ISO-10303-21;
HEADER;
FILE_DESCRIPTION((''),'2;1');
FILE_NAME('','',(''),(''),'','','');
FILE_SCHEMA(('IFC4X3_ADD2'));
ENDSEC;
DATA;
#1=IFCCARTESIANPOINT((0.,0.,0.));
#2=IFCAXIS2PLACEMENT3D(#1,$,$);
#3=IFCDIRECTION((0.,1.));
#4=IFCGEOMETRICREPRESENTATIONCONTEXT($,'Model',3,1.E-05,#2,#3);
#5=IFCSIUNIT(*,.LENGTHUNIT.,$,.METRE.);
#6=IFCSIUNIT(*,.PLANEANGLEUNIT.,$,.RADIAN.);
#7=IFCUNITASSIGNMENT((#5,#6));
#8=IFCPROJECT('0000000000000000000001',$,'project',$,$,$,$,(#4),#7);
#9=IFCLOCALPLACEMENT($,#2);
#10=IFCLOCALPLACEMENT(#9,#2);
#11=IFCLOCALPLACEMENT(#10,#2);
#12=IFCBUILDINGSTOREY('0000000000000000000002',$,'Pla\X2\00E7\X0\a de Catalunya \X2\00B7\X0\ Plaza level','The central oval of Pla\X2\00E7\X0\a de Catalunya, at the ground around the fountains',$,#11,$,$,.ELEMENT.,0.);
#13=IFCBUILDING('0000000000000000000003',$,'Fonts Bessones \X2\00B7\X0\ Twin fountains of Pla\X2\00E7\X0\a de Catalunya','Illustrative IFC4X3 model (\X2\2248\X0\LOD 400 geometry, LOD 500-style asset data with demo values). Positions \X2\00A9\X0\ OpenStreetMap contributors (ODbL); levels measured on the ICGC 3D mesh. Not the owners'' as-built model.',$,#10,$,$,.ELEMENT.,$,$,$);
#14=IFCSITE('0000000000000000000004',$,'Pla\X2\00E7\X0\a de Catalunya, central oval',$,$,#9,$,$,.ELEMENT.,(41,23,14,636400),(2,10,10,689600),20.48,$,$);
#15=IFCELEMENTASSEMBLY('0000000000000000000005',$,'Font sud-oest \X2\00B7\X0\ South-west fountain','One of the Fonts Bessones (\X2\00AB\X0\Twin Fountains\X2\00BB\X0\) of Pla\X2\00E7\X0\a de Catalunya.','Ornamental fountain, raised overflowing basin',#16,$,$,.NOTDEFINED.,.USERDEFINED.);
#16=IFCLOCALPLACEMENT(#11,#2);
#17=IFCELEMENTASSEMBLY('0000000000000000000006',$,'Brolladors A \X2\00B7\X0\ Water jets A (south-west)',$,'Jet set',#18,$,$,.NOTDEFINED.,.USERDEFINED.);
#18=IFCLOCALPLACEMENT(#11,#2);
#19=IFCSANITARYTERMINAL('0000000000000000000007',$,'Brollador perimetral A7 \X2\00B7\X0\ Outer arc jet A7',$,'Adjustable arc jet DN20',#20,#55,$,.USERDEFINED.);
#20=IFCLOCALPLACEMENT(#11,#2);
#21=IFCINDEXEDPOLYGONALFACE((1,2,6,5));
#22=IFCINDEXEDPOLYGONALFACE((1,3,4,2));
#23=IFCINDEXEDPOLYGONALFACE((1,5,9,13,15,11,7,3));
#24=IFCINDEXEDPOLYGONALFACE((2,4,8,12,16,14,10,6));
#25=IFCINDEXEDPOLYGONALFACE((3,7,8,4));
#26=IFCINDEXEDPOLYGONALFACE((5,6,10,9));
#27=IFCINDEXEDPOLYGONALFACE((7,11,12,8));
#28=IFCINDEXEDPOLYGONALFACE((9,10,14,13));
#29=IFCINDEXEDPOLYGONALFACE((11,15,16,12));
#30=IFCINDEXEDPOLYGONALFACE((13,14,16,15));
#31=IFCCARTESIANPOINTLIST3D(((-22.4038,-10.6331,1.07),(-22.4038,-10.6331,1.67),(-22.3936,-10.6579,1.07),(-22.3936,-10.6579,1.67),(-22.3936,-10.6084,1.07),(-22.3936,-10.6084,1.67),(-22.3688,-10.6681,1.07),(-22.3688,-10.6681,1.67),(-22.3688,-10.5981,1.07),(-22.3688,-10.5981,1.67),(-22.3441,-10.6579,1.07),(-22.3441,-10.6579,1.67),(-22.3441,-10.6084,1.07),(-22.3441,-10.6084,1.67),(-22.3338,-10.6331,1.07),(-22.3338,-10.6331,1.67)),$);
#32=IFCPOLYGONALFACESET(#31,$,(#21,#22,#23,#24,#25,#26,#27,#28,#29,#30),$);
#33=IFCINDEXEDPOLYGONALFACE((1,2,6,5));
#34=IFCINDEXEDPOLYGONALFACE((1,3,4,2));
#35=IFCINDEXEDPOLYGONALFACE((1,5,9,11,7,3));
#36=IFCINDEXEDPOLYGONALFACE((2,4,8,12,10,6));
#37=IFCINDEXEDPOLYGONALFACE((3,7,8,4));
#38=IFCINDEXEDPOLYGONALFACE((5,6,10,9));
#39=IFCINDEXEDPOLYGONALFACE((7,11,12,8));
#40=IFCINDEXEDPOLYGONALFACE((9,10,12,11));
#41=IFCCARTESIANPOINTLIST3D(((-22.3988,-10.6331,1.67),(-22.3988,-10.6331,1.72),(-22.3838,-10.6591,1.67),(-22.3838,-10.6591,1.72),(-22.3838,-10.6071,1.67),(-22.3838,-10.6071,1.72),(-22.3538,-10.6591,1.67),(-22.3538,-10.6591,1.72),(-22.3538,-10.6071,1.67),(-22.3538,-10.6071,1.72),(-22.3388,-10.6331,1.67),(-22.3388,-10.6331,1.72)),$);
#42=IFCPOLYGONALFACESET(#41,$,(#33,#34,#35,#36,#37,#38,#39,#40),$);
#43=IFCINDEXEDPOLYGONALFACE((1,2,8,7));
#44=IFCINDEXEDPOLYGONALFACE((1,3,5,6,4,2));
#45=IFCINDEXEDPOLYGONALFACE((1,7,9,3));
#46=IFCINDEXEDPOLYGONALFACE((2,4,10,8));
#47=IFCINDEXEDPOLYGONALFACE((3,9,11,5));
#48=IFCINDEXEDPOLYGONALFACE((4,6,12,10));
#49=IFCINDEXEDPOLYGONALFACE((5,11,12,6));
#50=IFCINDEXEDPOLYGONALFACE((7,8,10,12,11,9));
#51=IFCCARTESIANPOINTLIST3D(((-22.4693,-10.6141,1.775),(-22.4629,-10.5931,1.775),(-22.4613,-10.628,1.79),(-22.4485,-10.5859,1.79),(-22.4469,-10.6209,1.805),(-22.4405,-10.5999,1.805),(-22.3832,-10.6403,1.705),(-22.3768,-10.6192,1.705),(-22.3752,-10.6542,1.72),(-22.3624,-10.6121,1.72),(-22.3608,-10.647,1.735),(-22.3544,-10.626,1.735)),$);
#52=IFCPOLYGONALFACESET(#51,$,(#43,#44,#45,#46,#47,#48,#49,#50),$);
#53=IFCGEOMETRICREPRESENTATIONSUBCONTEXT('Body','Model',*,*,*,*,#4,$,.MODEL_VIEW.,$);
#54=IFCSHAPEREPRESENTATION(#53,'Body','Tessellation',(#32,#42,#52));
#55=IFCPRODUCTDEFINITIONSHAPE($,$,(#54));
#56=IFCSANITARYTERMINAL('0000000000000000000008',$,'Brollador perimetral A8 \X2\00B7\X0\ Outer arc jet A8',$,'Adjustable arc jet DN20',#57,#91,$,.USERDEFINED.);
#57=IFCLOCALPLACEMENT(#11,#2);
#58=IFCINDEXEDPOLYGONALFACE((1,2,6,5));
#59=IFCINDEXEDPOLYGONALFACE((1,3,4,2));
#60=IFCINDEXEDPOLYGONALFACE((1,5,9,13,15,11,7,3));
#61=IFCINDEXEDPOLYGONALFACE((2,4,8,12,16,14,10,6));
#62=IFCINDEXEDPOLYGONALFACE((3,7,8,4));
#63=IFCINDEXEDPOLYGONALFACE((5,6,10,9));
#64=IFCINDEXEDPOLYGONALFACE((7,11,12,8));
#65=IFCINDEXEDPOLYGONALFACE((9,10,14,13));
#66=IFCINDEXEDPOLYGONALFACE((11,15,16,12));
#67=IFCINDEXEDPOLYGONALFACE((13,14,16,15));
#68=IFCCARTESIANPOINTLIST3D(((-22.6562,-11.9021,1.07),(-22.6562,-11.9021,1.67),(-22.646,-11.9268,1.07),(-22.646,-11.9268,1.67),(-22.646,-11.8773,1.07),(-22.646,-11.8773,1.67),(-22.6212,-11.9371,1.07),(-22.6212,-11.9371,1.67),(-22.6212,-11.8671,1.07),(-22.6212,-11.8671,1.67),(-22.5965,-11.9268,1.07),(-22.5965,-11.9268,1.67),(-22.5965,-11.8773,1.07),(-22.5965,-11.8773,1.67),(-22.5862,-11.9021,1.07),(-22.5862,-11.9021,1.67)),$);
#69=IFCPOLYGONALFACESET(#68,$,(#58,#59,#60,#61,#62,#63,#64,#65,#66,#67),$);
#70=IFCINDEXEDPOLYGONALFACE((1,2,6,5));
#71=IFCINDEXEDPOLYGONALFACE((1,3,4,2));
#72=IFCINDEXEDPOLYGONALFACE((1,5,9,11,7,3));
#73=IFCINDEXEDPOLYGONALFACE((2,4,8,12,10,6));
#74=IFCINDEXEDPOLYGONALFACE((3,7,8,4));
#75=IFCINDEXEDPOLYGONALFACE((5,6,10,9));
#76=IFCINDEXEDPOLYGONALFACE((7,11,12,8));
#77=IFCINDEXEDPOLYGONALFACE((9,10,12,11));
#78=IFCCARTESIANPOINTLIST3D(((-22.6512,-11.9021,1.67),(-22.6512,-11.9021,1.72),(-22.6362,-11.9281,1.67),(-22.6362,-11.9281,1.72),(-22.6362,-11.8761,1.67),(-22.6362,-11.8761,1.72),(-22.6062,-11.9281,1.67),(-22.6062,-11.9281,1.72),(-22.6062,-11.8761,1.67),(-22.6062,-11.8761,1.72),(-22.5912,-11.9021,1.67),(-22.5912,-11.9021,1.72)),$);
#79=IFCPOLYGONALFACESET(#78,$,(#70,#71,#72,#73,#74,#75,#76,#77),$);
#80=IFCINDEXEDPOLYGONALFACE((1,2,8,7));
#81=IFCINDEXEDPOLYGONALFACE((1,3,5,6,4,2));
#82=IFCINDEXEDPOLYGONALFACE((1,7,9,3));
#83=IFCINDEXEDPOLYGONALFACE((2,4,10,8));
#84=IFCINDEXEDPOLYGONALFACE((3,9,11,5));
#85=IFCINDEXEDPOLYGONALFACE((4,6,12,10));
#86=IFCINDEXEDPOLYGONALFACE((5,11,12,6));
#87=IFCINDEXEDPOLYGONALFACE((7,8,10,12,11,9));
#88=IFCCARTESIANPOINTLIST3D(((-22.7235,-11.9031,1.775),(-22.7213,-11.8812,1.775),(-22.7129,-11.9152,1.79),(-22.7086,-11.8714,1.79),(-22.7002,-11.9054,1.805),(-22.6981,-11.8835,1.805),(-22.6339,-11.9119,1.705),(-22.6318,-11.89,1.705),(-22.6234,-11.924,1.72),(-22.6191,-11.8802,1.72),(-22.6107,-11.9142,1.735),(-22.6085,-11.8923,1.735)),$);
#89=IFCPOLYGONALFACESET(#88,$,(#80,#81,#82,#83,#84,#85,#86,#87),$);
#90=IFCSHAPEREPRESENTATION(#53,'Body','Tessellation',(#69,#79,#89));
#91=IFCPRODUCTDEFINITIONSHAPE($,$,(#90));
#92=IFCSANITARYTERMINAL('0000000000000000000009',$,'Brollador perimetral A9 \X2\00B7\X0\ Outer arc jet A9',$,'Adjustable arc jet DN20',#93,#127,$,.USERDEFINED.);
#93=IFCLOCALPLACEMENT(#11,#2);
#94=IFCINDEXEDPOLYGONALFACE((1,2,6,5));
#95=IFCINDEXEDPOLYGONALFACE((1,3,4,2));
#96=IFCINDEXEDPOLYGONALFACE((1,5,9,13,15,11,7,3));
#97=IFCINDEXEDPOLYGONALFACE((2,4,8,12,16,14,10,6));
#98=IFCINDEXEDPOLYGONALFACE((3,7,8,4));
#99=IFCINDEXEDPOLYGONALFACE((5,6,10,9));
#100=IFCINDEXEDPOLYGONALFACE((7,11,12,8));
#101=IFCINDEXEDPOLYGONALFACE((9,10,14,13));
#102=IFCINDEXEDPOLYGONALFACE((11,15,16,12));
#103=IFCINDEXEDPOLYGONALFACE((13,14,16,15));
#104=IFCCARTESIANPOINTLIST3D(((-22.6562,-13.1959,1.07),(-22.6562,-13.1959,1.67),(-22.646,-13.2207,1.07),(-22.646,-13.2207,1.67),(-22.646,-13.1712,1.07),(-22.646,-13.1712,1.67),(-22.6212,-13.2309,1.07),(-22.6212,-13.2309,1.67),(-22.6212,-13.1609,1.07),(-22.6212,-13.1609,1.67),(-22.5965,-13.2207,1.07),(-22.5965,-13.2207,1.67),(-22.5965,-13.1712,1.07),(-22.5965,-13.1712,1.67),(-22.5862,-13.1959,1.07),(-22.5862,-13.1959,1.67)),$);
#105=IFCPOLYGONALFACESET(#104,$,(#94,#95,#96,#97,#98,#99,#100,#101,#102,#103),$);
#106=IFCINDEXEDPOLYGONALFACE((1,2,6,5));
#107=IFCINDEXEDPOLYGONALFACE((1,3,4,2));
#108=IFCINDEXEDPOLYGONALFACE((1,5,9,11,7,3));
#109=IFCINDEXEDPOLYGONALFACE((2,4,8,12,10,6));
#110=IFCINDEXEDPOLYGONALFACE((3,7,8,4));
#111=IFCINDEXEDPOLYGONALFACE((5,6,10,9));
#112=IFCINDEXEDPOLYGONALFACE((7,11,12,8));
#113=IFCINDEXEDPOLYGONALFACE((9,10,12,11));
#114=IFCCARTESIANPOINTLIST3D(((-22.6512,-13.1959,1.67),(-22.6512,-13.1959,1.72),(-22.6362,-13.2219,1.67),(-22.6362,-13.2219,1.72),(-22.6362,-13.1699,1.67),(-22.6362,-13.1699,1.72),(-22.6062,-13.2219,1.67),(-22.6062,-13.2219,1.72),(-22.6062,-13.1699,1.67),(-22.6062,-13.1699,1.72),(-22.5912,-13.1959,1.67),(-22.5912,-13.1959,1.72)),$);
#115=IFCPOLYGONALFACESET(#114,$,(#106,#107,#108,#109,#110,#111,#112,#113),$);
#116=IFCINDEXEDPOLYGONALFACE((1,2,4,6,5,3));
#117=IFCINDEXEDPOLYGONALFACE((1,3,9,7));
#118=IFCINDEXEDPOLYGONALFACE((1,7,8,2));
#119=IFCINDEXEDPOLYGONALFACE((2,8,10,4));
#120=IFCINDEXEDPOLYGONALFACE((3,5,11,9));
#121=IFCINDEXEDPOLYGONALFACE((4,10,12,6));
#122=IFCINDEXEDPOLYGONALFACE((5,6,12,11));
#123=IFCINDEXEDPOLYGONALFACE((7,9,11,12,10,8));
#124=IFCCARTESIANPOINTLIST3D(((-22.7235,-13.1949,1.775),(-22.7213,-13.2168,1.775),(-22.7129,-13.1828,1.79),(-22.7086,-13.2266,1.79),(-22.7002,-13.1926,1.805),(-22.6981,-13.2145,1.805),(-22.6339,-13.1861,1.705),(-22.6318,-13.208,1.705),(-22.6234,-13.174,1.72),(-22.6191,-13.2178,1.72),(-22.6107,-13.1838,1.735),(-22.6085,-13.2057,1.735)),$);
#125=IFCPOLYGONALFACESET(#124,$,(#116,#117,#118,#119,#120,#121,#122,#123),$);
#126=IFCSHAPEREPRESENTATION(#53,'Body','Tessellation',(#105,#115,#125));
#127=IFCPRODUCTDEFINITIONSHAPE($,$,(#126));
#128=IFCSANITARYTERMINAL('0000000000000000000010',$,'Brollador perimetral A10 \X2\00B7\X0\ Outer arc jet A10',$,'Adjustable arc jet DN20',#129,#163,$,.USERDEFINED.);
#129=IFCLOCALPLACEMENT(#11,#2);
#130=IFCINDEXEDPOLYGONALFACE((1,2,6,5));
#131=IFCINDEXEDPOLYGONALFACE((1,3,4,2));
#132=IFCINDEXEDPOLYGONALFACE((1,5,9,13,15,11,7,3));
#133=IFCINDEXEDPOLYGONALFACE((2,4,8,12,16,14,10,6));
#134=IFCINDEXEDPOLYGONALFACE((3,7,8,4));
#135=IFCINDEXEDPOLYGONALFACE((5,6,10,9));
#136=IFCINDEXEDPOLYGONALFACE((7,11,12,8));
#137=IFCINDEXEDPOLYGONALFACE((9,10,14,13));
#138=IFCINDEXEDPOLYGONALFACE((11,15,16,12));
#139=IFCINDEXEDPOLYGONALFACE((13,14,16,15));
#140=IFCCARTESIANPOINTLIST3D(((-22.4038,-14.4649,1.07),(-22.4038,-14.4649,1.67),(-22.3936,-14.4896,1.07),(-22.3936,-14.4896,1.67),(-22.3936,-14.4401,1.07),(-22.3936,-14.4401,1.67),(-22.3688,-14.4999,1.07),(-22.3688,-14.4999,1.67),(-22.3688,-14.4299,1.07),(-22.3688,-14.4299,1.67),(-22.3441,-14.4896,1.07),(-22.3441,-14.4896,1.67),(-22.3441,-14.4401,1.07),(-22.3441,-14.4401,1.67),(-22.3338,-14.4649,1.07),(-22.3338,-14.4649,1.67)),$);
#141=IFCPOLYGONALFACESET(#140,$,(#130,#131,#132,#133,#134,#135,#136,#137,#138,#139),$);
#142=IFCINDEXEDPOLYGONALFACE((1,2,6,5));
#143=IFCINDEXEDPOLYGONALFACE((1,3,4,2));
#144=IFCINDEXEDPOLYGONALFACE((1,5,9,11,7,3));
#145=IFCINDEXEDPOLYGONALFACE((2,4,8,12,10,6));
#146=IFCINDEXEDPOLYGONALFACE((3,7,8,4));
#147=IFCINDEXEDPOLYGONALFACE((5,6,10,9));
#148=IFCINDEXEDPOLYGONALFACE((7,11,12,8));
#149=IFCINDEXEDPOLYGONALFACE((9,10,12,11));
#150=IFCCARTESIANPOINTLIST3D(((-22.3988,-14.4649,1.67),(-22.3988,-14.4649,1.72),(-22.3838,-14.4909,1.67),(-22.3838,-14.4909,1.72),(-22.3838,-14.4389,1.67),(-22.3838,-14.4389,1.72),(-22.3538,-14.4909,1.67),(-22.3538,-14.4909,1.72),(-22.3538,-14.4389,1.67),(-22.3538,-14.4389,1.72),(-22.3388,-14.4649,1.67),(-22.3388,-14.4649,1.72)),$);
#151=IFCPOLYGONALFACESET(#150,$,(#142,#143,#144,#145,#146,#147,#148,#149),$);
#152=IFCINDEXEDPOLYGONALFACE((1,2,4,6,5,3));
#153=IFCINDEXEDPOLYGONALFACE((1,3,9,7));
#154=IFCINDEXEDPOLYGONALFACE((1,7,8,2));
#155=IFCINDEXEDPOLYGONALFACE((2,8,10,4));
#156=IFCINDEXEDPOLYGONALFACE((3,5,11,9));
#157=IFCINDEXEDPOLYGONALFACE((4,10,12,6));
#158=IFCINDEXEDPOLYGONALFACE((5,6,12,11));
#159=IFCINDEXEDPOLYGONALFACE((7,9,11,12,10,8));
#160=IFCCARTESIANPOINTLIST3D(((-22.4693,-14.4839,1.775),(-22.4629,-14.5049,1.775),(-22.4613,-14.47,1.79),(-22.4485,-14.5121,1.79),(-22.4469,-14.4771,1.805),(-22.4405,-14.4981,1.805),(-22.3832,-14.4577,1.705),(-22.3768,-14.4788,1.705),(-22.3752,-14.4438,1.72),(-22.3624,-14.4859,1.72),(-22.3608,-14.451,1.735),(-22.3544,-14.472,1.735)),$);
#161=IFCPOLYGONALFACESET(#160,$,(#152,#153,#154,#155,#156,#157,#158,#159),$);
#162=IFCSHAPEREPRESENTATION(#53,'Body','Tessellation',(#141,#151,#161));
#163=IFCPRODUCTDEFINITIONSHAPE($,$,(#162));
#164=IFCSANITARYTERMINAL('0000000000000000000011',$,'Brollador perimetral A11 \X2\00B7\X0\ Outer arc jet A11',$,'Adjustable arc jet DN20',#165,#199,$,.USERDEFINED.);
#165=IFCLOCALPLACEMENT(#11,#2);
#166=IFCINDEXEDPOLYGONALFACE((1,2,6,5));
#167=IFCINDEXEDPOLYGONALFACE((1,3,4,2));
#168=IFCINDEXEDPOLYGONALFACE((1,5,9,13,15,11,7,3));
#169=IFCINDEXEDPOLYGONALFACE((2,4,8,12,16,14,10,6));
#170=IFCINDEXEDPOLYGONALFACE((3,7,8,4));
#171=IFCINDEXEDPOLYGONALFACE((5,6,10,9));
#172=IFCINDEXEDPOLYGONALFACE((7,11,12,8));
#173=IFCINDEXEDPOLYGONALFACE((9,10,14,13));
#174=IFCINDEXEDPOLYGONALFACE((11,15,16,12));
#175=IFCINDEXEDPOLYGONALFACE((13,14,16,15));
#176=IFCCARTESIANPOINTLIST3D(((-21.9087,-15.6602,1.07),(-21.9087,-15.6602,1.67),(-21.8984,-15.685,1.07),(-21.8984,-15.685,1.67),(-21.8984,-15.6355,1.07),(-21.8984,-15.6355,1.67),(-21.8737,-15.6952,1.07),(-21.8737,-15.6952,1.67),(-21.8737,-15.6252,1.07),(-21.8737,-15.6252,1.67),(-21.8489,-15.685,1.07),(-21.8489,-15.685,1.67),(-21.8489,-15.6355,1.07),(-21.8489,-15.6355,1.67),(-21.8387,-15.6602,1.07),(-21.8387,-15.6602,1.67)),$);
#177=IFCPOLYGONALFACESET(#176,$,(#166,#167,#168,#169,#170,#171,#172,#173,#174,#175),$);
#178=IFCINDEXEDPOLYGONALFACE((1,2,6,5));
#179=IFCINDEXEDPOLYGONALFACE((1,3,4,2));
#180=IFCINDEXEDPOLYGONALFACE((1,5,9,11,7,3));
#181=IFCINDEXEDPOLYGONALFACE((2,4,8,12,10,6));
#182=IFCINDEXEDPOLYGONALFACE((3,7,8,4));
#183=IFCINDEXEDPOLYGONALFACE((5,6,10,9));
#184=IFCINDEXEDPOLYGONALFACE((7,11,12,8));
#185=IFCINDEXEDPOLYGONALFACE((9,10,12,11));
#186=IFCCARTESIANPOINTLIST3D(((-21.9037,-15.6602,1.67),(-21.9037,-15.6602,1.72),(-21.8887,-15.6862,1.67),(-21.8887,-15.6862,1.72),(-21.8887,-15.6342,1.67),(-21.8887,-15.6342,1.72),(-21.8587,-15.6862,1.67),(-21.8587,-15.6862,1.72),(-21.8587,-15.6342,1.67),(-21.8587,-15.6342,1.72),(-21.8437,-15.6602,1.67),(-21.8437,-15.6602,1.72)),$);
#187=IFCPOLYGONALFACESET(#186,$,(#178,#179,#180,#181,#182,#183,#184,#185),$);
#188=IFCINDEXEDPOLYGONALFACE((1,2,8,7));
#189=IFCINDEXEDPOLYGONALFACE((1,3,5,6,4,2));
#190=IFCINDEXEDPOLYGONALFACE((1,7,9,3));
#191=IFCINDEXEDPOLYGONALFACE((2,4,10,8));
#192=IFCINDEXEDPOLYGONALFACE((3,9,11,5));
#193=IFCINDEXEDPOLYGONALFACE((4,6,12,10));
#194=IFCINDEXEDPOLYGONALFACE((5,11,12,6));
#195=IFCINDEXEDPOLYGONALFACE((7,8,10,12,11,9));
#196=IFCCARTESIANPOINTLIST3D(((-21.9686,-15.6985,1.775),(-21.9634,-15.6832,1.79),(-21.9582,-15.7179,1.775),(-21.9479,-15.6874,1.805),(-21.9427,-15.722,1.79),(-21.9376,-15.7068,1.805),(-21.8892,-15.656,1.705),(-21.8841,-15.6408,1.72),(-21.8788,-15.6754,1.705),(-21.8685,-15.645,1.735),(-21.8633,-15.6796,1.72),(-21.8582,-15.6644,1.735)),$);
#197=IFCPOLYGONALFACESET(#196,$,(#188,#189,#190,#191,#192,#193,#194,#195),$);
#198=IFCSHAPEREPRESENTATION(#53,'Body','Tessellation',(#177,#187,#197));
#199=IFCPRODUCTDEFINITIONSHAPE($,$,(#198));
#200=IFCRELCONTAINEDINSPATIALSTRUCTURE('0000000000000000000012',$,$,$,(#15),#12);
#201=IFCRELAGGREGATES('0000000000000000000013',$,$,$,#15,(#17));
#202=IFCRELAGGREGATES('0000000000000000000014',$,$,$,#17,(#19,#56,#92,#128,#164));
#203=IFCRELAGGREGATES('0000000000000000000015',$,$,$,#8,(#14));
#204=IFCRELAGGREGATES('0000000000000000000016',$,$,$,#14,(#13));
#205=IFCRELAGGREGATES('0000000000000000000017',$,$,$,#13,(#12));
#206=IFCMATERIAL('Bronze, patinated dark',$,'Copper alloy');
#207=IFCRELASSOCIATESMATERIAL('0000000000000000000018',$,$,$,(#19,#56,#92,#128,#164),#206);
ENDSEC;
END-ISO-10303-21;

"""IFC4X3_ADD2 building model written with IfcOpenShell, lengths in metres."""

from ifc_helpers import new_model, si_unit, direction, frame, origin, place, context, subcontext, project, spatial, polyline, outline, extrude, material, element, aggregate, save


model = new_model("IFC4X3_ADD2")

# Units and contexts
model_context = context("Model", 3, precision=1e-05, world=origin(), true_north=direction((0.0, 1.0)))
body_context = subcontext(model_context, "Body", "Model", "MODEL_VIEW")
ifc_project = project(units=[si_unit("LENGTHUNIT", "METRE"), si_unit("PLANEANGLEUNIT", "RADIAN")], contexts=[model_context])

# Site, building, storey
site_placement = place(None, origin())
site = spatial("IfcSite", under=ifc_project, at=site_placement, Name="Plaça de Catalunya, central oval", CompositionType="ELEMENT", RefLatitude=(41, 23, 14, 636400), RefLongitude=(2, 10, 10, 689600), RefElevation=20.48)
building_placement = place(site_placement, origin())
building = spatial("IfcBuilding", under=site, at=building_placement, Name="Fonts Bessones · Twin fountains of Plaça de Catalunya", Description="Illustrative IFC4X3 model (≈LOD 400 geometry, LOD 500-style asset data with demo values). Positions © OpenStreetMap contributors (ODbL); levels measured on the ICGC 3D mesh. Not the owners' as-built model.", CompositionType="ELEMENT")
storey_placement = place(building_placement, origin())
storey = spatial("IfcBuildingStorey", under=building, at=storey_placement, Name="Plaça de Catalunya · Plaza level", Description="The central oval of Plaça de Catalunya, at the ground around the fountains", CompositionType="ELEMENT", Elevation=0.0)

# Element assemblies, sanitary terminals
assembly_1_placement = place(building_placement, origin())
assembly_1 = element("IfcElementAssembly", 1, at=assembly_1_placement, inside=storey, Name="Font sud-oest · South-west fountain", Description="One of the Fonts Bessones («Twin Fountains») of Plaça de Catalunya.", ObjectType="Ornamental fountain, raised overflowing basin", AssemblyPlace="NOTDEFINED", PredefinedType="USERDEFINED")
assembly_2_placement = place(building_placement, origin())
assembly_2 = element("IfcElementAssembly", 2, at=assembly_2_placement, Name="Brolladors A · Water jets A (south-west)", ObjectType="Jet set", AssemblyPlace="NOTDEFINED", PredefinedType="USERDEFINED")
aggregate(assembly_1, [assembly_2])
ifc_material = material(Name="Bronze, patinated dark", Category="Copper alloy")
sanitary_terminal_1_placement = place(building_placement, origin())
sanitary_terminal_1 = element("IfcSanitaryTerminal", 3, at=sanitary_terminal_1_placement, material=ifc_material, Name="Brollador perimetral A7 · Outer arc jet A7", ObjectType="Adjustable arc jet DN20", PredefinedType="USERDEFINED", context=body_context, shape_type="SweptSolid", body=[
    extrude(outline(polyline([(-22.3338, -10.6331), (-22.3441, -10.6084), (-22.3688, -10.5981), (-22.3936, -10.6084), (-22.4038, -10.6331), (-22.3936, -10.6579), (-22.3688, -10.6681), (-22.3441, -10.6579), (-22.3338, -10.6331)])), frame((0.0, 0.0, 1.07)), (0.0, 0.0, 1.0), 0.6),
    extrude(outline(polyline([(-22.3388, -10.6331), (-22.3538, -10.6071), (-22.3838, -10.6071), (-22.3988, -10.6331), (-22.3838, -10.6591), (-22.3538, -10.6591), (-22.3388, -10.6331)])), frame((0.0, 0.0, 1.67)), (0.0, 0.0, 1.0), 0.05),
    extrude(outline(polyline([(0.022, 0.0), (0.011, 0.0191), (-0.011, 0.0191), (-0.022, 0.0), (-0.011, -0.0191), (0.011, -0.0191), (0.022, 0.0)])), frame((-22.3688, -10.6331, 1.72), z_axis=(-0.755363, 0.229137, 0.613941), x_axis=(0.290285, 0.95694, 0.0)), (0.0, 0.0, 1.0), 0.114),
])
sanitary_terminal_2_placement = place(building_placement, origin())
sanitary_terminal_2 = element("IfcSanitaryTerminal", 4, at=sanitary_terminal_2_placement, material=ifc_material, Name="Brollador perimetral A8 · Outer arc jet A8", ObjectType="Adjustable arc jet DN20", PredefinedType="USERDEFINED", context=body_context, shape_type="SweptSolid", body=[
    extrude(outline(polyline([(-22.5862, -11.9021), (-22.5965, -11.8773), (-22.6212, -11.8671), (-22.646, -11.8773), (-22.6562, -11.9021), (-22.646, -11.9268), (-22.6212, -11.9371), (-22.5965, -11.9268), (-22.5862, -11.9021)])), frame((0.0, 0.0, 1.07)), (0.0, 0.0, 1.0), 0.6),
    extrude(outline(polyline([(-22.5912, -11.9021), (-22.6062, -11.8761), (-22.6362, -11.8761), (-22.6512, -11.9021), (-22.6362, -11.9281), (-22.6062, -11.9281), (-22.5912, -11.9021)])), frame((0.0, 0.0, 1.67)), (0.0, 0.0, 1.0), 0.05),
    extrude(outline(polyline([(0.022, 0.0), (0.011, 0.0191), (-0.011, 0.0191), (-0.022, 0.0), (-0.011, -0.0191), (0.011, -0.0191), (0.022, 0.0)])), frame((-22.6212, -11.9021, 1.72), z_axis=(-0.785551, 0.07737, 0.613941), x_axis=(0.098017, 0.995185, 0.0)), (0.0, 0.0, 1.0), 0.114),
])
sanitary_terminal_3_placement = place(building_placement, origin())
sanitary_terminal_3 = element("IfcSanitaryTerminal", 5, at=sanitary_terminal_3_placement, material=ifc_material, Name="Brollador perimetral A9 · Outer arc jet A9", ObjectType="Adjustable arc jet DN20", PredefinedType="USERDEFINED", context=body_context, shape_type="SweptSolid", body=[
    extrude(outline(polyline([(-22.5862, -13.1959), (-22.5965, -13.1712), (-22.6212, -13.1609), (-22.646, -13.1712), (-22.6562, -13.1959), (-22.646, -13.2207), (-22.6212, -13.2309), (-22.5965, -13.2207), (-22.5862, -13.1959)])), frame((0.0, 0.0, 1.07)), (0.0, 0.0, 1.0), 0.6),
    extrude(outline(polyline([(-22.5912, -13.1959), (-22.6062, -13.1699), (-22.6362, -13.1699), (-22.6512, -13.1959), (-22.6362, -13.2219), (-22.6062, -13.2219), (-22.5912, -13.1959)])), frame((0.0, 0.0, 1.67)), (0.0, 0.0, 1.0), 0.05),
    extrude(outline(polyline([(0.022, 0.0), (0.011, 0.0191), (-0.011, 0.0191), (-0.022, 0.0), (-0.011, -0.0191), (0.011, -0.0191), (0.022, 0.0)])), frame((-22.6212, -13.1959, 1.72), z_axis=(-0.785551, -0.07737, 0.613941), x_axis=(-0.098017, 0.995185, 0.0)), (0.0, 0.0, 1.0), 0.114),
])
sanitary_terminal_4_placement = place(building_placement, origin())
sanitary_terminal_4 = element("IfcSanitaryTerminal", 6, at=sanitary_terminal_4_placement, material=ifc_material, Name="Brollador perimetral A10 · Outer arc jet A10", ObjectType="Adjustable arc jet DN20", PredefinedType="USERDEFINED", context=body_context, shape_type="SweptSolid", body=[
    extrude(outline(polyline([(-22.3338, -14.4649), (-22.3441, -14.4401), (-22.3688, -14.4299), (-22.3936, -14.4401), (-22.4038, -14.4649), (-22.3936, -14.4896), (-22.3688, -14.4999), (-22.3441, -14.4896), (-22.3338, -14.4649)])), frame((0.0, 0.0, 1.07)), (0.0, 0.0, 1.0), 0.6),
    extrude(outline(polyline([(-22.3388, -14.4649), (-22.3538, -14.4389), (-22.3838, -14.4389), (-22.3988, -14.4649), (-22.3838, -14.4909), (-22.3538, -14.4909), (-22.3388, -14.4649)])), frame((0.0, 0.0, 1.67)), (0.0, 0.0, 1.0), 0.05),
    extrude(outline(polyline([(0.022, 0.0), (0.011, 0.0191), (-0.011, 0.0191), (-0.022, 0.0), (-0.011, -0.0191), (0.011, -0.0191), (0.022, 0.0)])), frame((-22.3688, -14.4649, 1.72), z_axis=(-0.755363, -0.229137, 0.613941), x_axis=(-0.290285, 0.95694, 0.0)), (0.0, 0.0, 1.0), 0.114),
])
sanitary_terminal_5_placement = place(building_placement, origin())
sanitary_terminal_5 = element("IfcSanitaryTerminal", 7, at=sanitary_terminal_5_placement, material=ifc_material, Name="Brollador perimetral A11 · Outer arc jet A11", ObjectType="Adjustable arc jet DN20", PredefinedType="USERDEFINED", context=body_context, shape_type="SweptSolid", body=[
    extrude(outline(polyline([(-21.8387, -15.6602), (-21.8489, -15.6355), (-21.8737, -15.6252), (-21.8984, -15.6355), (-21.9087, -15.6602), (-21.8984, -15.685), (-21.8737, -15.6952), (-21.8489, -15.685), (-21.8387, -15.6602)])), frame((0.0, 0.0, 1.07)), (0.0, 0.0, 1.0), 0.6),
    extrude(outline(polyline([(-21.8437, -15.6602), (-21.8587, -15.6342), (-21.8887, -15.6342), (-21.9037, -15.6602), (-21.8887, -15.6862), (-21.8587, -15.6862), (-21.8437, -15.6602)])), frame((0.0, 0.0, 1.67)), (0.0, 0.0, 1.0), 0.05),
    extrude(outline(polyline([(0.022, 0.0), (0.011, 0.0191), (-0.011, 0.0191), (-0.022, 0.0), (-0.011, -0.0191), (0.011, -0.0191), (0.022, 0.0)])), frame((-21.8737, -15.6602, 1.72), z_axis=(-0.696147, -0.372098, 0.613941), x_axis=(-0.471397, 0.881921, 0.0)), (0.0, 0.0, 1.0), 0.114),
])
aggregate(assembly_2, [sanitary_terminal_1, sanitary_terminal_2, sanitary_terminal_3, sanitary_terminal_4, sanitary_terminal_5])

save(model, "model.ifc")
